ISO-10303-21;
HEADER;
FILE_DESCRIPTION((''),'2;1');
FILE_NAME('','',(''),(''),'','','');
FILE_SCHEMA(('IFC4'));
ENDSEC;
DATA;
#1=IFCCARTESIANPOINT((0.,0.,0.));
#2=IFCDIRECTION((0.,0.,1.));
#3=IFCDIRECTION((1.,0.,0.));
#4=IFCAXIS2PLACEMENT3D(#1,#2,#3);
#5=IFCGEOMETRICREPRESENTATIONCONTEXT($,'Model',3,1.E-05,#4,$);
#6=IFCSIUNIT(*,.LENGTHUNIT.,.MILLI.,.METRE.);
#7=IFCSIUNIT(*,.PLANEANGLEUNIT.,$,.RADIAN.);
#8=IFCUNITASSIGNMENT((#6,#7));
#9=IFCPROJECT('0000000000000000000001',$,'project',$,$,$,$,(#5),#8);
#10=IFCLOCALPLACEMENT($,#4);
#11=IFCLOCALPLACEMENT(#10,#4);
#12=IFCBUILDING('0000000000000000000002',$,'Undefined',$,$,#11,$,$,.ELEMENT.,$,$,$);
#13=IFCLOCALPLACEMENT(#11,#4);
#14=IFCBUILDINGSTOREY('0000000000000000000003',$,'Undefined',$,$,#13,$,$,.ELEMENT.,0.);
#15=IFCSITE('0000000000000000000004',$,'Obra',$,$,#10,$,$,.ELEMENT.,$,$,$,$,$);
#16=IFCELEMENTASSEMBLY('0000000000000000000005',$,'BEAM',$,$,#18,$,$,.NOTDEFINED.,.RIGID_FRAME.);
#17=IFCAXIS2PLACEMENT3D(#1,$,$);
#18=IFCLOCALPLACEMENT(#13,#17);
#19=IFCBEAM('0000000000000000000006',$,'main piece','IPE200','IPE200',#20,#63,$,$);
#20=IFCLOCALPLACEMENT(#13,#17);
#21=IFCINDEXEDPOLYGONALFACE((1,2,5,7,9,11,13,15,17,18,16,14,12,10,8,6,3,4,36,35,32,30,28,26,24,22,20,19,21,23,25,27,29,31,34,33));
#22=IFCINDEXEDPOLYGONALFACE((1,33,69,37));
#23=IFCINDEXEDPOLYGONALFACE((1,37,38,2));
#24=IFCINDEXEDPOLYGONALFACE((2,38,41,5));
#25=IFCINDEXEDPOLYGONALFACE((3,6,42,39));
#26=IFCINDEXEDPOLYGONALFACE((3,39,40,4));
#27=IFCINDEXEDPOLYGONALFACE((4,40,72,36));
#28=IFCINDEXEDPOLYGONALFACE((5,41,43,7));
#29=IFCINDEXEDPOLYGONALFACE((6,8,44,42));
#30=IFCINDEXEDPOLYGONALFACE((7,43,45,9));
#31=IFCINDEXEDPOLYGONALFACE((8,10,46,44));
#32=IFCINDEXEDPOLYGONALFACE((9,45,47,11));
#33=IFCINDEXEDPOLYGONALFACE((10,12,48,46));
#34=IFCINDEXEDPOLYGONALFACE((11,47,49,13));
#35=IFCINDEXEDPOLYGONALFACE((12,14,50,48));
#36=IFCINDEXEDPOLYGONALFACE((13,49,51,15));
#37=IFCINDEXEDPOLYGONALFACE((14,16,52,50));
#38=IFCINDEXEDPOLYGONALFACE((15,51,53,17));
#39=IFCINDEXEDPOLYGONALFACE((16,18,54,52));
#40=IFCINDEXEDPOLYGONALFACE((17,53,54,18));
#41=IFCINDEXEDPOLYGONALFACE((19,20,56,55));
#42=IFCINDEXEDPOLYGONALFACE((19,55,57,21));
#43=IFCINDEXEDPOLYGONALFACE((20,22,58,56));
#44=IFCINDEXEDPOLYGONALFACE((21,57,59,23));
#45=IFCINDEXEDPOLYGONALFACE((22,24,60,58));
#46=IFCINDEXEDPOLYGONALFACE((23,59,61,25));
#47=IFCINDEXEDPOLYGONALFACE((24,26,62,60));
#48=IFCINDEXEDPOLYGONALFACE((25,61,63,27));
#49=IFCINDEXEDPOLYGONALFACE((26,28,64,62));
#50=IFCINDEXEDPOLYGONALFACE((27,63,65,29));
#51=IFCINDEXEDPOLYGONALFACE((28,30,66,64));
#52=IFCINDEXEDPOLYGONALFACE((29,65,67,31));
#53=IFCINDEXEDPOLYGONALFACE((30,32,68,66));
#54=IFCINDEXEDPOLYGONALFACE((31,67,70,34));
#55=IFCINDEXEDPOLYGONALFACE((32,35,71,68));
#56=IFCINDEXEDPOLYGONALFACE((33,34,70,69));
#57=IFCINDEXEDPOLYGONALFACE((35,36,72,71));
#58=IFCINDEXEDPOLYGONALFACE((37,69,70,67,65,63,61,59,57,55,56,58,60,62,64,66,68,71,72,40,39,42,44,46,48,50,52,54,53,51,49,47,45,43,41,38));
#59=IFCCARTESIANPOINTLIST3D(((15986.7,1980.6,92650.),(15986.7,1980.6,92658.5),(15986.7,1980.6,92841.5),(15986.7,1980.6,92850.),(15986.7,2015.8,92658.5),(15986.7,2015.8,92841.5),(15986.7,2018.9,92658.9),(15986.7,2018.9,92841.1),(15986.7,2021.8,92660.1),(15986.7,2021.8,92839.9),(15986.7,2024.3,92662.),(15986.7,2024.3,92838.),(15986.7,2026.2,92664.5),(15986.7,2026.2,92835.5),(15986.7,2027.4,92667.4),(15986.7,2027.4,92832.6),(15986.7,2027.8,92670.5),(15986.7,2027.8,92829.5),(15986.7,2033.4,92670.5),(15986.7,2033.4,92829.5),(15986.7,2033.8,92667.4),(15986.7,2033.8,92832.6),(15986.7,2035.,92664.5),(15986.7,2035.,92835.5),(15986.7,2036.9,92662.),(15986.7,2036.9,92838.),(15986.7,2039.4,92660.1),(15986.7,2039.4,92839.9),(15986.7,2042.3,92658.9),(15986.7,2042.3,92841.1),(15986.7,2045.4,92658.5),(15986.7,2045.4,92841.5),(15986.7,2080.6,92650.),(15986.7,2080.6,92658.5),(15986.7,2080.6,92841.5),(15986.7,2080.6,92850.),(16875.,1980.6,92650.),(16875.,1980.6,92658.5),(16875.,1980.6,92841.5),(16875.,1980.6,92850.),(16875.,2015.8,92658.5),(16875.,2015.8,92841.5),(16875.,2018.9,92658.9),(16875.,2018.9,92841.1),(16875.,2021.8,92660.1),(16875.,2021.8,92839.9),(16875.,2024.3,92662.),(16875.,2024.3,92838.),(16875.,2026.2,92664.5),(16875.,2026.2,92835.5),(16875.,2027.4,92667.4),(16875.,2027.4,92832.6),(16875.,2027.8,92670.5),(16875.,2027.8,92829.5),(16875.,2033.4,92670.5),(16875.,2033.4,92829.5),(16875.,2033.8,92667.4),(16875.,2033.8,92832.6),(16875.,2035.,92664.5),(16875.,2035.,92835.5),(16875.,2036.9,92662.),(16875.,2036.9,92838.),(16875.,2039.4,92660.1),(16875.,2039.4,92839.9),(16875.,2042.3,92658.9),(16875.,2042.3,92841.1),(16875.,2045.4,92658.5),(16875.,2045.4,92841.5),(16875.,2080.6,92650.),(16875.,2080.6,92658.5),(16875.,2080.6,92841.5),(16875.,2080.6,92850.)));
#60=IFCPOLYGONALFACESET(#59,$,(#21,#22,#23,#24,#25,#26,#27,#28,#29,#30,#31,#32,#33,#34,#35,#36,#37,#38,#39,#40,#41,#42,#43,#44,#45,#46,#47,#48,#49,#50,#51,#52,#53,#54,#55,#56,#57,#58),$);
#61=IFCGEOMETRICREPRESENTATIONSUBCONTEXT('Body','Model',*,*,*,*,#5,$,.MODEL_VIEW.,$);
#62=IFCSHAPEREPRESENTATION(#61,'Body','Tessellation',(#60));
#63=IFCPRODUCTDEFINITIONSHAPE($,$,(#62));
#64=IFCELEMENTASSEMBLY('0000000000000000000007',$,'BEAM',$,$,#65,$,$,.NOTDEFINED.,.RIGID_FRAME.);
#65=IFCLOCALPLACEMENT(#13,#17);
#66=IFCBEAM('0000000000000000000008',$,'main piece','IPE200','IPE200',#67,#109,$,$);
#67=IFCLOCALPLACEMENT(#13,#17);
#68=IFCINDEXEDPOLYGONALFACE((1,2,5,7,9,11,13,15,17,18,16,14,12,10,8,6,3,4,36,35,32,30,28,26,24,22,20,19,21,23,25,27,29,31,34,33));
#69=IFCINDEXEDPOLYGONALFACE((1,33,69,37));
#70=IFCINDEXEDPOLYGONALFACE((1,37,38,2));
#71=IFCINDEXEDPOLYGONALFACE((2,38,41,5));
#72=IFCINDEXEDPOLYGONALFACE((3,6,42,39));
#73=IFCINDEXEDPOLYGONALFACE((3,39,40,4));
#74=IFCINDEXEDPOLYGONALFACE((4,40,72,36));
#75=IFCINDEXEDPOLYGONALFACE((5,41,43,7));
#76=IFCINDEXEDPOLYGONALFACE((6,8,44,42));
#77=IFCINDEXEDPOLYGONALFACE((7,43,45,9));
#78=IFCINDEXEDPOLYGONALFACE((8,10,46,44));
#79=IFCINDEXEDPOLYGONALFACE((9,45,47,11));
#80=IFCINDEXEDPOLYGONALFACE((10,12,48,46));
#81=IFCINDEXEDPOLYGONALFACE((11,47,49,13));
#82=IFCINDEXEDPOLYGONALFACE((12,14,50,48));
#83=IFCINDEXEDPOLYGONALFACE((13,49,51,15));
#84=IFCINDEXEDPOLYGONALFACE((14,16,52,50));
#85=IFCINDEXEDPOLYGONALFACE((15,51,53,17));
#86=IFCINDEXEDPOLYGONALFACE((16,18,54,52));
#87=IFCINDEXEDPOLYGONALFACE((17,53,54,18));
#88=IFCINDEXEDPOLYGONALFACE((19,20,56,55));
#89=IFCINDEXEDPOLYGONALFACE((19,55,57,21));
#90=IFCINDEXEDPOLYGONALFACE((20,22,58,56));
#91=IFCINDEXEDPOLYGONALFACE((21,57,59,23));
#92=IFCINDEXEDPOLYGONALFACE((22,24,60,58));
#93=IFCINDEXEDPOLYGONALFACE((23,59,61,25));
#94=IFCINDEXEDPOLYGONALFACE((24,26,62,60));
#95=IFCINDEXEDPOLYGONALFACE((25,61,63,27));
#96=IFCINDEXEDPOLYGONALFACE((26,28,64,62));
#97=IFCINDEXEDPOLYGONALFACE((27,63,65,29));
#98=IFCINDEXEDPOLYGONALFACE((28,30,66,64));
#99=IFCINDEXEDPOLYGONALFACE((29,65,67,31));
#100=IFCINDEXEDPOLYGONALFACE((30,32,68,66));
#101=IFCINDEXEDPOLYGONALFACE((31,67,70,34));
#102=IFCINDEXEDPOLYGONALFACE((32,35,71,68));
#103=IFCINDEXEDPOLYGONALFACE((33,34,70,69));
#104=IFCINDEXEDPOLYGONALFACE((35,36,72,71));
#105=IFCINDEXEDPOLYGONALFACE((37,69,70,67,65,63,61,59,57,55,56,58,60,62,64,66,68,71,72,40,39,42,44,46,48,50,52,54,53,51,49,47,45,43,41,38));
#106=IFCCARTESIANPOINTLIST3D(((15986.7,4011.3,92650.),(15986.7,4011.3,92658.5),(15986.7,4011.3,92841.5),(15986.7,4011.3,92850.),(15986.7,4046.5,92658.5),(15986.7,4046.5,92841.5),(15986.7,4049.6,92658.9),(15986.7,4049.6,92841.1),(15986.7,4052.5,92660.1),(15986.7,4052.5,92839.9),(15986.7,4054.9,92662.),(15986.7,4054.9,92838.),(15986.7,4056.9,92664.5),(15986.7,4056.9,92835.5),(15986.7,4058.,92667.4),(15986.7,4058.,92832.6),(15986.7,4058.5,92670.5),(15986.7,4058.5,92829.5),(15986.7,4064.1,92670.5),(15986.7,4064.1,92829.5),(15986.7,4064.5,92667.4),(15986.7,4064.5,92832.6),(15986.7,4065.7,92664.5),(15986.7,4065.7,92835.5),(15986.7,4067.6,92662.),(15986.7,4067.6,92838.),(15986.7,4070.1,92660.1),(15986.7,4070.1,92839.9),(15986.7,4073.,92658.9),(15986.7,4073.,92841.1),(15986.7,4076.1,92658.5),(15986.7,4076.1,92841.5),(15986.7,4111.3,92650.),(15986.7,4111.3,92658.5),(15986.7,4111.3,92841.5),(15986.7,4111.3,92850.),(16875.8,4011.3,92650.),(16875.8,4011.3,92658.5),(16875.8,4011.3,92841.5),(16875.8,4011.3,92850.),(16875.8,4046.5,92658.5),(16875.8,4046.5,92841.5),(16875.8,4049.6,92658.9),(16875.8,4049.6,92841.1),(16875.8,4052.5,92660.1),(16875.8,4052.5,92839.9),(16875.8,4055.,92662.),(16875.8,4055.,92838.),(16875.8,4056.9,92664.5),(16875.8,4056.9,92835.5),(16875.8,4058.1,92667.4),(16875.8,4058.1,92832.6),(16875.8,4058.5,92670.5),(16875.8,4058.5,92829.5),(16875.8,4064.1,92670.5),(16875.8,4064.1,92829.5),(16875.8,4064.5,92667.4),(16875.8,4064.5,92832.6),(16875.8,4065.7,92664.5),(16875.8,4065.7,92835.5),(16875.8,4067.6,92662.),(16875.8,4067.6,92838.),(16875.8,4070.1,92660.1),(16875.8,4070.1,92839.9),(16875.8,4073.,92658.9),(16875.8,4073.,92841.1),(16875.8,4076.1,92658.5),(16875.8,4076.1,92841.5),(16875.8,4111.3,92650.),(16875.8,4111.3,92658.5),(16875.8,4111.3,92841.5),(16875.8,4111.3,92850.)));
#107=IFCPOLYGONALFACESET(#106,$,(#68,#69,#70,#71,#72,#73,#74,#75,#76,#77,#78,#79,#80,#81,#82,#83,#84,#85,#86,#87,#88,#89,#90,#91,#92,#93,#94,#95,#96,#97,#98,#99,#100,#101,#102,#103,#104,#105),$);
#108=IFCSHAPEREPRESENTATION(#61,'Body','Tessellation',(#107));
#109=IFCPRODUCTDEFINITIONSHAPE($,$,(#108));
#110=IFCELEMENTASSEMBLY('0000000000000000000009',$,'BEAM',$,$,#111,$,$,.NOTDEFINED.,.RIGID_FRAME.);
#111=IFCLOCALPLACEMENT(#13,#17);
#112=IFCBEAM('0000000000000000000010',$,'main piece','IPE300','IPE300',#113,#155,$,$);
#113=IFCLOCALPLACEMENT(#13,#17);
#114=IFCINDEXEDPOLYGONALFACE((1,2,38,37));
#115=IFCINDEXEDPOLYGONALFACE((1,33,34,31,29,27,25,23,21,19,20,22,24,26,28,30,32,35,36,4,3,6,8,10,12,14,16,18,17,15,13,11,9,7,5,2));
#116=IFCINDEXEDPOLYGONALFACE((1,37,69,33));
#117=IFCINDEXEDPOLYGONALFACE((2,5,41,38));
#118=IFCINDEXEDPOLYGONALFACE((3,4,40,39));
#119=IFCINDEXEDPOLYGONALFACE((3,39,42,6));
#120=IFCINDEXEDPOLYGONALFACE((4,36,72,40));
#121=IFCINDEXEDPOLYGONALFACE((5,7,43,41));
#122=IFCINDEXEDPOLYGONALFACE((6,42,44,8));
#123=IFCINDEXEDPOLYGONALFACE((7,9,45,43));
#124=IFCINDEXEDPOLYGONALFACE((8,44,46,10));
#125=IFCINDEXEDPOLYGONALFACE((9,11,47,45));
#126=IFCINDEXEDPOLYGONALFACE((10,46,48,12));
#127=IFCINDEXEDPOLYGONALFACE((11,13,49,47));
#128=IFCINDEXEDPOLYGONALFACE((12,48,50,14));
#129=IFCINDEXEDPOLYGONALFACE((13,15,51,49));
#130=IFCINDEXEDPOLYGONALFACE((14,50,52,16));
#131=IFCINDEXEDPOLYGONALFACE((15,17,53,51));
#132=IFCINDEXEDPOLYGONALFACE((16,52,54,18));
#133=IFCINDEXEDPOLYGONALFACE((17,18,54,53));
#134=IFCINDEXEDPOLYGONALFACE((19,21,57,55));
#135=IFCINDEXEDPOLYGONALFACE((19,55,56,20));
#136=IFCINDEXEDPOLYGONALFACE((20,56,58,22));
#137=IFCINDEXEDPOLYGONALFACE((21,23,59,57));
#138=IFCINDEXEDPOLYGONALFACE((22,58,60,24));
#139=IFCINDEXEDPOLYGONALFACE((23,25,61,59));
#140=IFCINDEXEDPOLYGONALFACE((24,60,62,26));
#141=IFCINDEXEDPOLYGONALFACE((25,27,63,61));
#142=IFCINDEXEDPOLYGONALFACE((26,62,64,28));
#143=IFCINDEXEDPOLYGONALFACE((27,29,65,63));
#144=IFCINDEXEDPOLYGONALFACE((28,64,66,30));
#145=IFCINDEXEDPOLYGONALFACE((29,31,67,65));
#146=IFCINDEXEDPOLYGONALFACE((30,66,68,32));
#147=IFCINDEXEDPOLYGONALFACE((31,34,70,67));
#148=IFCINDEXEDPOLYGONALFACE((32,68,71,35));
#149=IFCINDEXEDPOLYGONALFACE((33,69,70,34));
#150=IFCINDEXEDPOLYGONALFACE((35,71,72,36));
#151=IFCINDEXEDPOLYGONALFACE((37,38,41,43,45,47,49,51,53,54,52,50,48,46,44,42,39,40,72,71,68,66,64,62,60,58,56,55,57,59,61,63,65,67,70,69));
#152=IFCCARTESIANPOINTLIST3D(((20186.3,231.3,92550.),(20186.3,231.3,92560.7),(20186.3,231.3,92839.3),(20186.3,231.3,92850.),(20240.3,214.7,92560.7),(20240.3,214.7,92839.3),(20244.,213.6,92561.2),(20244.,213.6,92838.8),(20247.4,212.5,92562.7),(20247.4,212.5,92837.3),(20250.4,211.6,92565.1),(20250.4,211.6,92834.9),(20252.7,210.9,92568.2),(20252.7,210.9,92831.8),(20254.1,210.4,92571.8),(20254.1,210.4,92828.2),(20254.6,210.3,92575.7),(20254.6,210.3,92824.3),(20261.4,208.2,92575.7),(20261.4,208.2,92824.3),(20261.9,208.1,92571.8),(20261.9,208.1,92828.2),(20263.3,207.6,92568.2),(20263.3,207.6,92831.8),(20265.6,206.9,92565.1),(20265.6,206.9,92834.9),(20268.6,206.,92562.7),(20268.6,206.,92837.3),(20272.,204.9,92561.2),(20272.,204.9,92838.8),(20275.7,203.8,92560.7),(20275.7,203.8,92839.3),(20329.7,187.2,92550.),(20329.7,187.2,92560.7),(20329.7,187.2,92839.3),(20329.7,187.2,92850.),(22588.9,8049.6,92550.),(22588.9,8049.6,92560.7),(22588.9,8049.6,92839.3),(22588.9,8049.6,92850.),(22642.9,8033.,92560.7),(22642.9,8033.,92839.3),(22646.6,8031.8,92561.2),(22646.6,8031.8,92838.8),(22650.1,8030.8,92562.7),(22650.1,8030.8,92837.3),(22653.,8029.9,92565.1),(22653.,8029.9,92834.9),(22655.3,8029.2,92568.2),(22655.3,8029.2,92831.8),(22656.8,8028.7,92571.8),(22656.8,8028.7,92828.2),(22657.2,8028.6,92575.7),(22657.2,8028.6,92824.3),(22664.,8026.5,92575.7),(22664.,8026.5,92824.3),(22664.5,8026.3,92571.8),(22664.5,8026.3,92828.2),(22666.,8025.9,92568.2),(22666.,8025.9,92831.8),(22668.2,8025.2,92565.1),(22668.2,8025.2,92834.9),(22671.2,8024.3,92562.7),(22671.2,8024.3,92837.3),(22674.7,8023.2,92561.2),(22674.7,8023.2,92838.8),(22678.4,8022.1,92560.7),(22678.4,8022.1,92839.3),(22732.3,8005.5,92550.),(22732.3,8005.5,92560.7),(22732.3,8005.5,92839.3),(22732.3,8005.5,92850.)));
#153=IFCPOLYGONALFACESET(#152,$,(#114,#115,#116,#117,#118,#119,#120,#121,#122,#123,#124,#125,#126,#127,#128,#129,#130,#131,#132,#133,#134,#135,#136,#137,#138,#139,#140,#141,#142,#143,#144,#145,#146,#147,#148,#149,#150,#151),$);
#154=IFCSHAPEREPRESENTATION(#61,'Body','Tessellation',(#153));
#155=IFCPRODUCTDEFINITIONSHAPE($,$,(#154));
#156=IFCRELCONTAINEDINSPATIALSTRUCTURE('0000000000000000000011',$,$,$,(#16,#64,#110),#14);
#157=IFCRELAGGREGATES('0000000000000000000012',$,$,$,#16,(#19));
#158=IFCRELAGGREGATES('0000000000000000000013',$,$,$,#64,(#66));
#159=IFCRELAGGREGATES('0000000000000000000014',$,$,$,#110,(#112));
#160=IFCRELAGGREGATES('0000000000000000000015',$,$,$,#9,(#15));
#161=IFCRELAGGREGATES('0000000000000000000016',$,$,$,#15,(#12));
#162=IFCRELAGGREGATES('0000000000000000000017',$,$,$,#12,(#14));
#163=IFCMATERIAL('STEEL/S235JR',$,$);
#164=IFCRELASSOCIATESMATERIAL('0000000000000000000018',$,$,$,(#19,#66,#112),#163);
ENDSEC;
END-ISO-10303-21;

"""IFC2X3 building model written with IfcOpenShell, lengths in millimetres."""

from ifc_helpers import new_model, si_unit, frame, origin_with_axes, origin_2d_with_axis, place, context, subcontext, project, spatial, i_section, extrude, material, element, aggregate, save


model = new_model("IFC2X3")

# Units and contexts
model_context = context("Model", 3, precision=1e-05, world=origin_with_axes())
body_context = subcontext(model_context, "Body", "Model", "MODEL_VIEW")
ifc_project = project(units=[si_unit("LENGTHUNIT", "METRE", prefix="MILLI"), si_unit("PLANEANGLEUNIT", "RADIAN")], contexts=[model_context])

# Site, building, storey
site_placement = place(None, origin_with_axes())
site = spatial("IfcSite", under=ifc_project, at=site_placement, Name="Obra", CompositionType="ELEMENT")
building_placement = place(site_placement, origin_with_axes())
building = spatial("IfcBuilding", under=site, at=building_placement, Name="Undefined", CompositionType="ELEMENT")
storey_placement = place(building_placement, origin_with_axes())
storey = spatial("IfcBuildingStorey", under=building, at=storey_placement, Name="Undefined", CompositionType="ELEMENT", Elevation=0.0)

# Element assemblies, beams
ifc_material = material(Name="STEEL/S235JR")
assembly_1_placement = place(storey_placement, origin_with_axes())
assembly_1 = element("IfcElementAssembly", 1, at=assembly_1_placement, inside=storey, Name="BEAM", AssemblyPlace="NOTDEFINED", PredefinedType="RIGID_FRAME")
beam_1_placement = place(assembly_1_placement, frame((16875.0, 2030.6, 92750.0), z_axis=(0.0, 0.0, 1.0), x_axis=(-1.0, 0.0, 0.0)))
beam_1 = element("IfcBeam", 2, at=beam_1_placement, material=ifc_material, Name="main piece", Description="IPE200", ObjectType="IPE200", context=body_context, shape_type="SweptSolid", body=[
    extrude(i_section(OverallWidth=100.0, OverallDepth=200.0, WebThickness=5.6, FlangeThickness=8.5, FilletRadius=12.0, at=origin_2d_with_axis()), frame((888.3, 0.0, 0.0), z_axis=(-1.0, 0.0, 0.0), x_axis=(0.0, -1.0, 0.0)), (0.0, 0.0, 1.0), 888.3),
])
aggregate(assembly_1, [beam_1])
assembly_2_placement = place(storey_placement, origin_with_axes())
assembly_2 = element("IfcElementAssembly", 3, at=assembly_2_placement, inside=storey, Name="BEAM", AssemblyPlace="NOTDEFINED", PredefinedType="RIGID_FRAME")
beam_2_placement = place(assembly_2_placement, frame((16875.8, 4061.3, 92750.0), z_axis=(0.0, 0.0, 1.0), x_axis=(-1.0, -0.000044, 0.0)))
beam_2 = element("IfcBeam", 4, at=beam_2_placement, material=ifc_material, Name="main piece", Description="IPE200", ObjectType="IPE200", context=body_context, shape_type="SweptSolid", body=[
    extrude(i_section(OverallWidth=100.0, OverallDepth=200.0, WebThickness=5.6, FlangeThickness=8.5, FilletRadius=12.0, at=origin_2d_with_axis()), frame((889.1, 0.0, 0.0), z_axis=(-1.0, 0.0, 0.0), x_axis=(0.0, -1.0, 0.0)), (0.0, 0.0, 1.0), 889.1),
])
aggregate(assembly_2, [beam_2])
assembly_3_placement = place(storey_placement, origin_with_axes())
assembly_3 = element("IfcElementAssembly", 5, at=assembly_3_placement, inside=storey, Name="BEAM", AssemblyPlace="NOTDEFINED", PredefinedType="RIGID_FRAME")
beam_3_placement = place(assembly_3_placement, frame((20258.0, 209.2, 92700.0), z_axis=(0.0, 0.0, 1.0), x_axis=(0.293752, 0.955882, 0.0)))
beam_3 = element("IfcBeam", 6, at=beam_3_placement, material=ifc_material, Name="main piece", Description="IPE300", ObjectType="IPE300", context=body_context, shape_type="SweptSolid", body=[
    extrude(i_section(OverallWidth=150.0, OverallDepth=300.0, WebThickness=7.1, FlangeThickness=10.7, FilletRadius=15.0, at=origin_2d_with_axis()), frame((8179.1, 0.0, 0.0), z_axis=(-1.0, 0.0, 0.0), x_axis=(0.0, -1.0, 0.0)), (0.0, 0.0, 1.0), 8179.1),
])
aggregate(assembly_3, [beam_3])

save(model, "model.ifc")
